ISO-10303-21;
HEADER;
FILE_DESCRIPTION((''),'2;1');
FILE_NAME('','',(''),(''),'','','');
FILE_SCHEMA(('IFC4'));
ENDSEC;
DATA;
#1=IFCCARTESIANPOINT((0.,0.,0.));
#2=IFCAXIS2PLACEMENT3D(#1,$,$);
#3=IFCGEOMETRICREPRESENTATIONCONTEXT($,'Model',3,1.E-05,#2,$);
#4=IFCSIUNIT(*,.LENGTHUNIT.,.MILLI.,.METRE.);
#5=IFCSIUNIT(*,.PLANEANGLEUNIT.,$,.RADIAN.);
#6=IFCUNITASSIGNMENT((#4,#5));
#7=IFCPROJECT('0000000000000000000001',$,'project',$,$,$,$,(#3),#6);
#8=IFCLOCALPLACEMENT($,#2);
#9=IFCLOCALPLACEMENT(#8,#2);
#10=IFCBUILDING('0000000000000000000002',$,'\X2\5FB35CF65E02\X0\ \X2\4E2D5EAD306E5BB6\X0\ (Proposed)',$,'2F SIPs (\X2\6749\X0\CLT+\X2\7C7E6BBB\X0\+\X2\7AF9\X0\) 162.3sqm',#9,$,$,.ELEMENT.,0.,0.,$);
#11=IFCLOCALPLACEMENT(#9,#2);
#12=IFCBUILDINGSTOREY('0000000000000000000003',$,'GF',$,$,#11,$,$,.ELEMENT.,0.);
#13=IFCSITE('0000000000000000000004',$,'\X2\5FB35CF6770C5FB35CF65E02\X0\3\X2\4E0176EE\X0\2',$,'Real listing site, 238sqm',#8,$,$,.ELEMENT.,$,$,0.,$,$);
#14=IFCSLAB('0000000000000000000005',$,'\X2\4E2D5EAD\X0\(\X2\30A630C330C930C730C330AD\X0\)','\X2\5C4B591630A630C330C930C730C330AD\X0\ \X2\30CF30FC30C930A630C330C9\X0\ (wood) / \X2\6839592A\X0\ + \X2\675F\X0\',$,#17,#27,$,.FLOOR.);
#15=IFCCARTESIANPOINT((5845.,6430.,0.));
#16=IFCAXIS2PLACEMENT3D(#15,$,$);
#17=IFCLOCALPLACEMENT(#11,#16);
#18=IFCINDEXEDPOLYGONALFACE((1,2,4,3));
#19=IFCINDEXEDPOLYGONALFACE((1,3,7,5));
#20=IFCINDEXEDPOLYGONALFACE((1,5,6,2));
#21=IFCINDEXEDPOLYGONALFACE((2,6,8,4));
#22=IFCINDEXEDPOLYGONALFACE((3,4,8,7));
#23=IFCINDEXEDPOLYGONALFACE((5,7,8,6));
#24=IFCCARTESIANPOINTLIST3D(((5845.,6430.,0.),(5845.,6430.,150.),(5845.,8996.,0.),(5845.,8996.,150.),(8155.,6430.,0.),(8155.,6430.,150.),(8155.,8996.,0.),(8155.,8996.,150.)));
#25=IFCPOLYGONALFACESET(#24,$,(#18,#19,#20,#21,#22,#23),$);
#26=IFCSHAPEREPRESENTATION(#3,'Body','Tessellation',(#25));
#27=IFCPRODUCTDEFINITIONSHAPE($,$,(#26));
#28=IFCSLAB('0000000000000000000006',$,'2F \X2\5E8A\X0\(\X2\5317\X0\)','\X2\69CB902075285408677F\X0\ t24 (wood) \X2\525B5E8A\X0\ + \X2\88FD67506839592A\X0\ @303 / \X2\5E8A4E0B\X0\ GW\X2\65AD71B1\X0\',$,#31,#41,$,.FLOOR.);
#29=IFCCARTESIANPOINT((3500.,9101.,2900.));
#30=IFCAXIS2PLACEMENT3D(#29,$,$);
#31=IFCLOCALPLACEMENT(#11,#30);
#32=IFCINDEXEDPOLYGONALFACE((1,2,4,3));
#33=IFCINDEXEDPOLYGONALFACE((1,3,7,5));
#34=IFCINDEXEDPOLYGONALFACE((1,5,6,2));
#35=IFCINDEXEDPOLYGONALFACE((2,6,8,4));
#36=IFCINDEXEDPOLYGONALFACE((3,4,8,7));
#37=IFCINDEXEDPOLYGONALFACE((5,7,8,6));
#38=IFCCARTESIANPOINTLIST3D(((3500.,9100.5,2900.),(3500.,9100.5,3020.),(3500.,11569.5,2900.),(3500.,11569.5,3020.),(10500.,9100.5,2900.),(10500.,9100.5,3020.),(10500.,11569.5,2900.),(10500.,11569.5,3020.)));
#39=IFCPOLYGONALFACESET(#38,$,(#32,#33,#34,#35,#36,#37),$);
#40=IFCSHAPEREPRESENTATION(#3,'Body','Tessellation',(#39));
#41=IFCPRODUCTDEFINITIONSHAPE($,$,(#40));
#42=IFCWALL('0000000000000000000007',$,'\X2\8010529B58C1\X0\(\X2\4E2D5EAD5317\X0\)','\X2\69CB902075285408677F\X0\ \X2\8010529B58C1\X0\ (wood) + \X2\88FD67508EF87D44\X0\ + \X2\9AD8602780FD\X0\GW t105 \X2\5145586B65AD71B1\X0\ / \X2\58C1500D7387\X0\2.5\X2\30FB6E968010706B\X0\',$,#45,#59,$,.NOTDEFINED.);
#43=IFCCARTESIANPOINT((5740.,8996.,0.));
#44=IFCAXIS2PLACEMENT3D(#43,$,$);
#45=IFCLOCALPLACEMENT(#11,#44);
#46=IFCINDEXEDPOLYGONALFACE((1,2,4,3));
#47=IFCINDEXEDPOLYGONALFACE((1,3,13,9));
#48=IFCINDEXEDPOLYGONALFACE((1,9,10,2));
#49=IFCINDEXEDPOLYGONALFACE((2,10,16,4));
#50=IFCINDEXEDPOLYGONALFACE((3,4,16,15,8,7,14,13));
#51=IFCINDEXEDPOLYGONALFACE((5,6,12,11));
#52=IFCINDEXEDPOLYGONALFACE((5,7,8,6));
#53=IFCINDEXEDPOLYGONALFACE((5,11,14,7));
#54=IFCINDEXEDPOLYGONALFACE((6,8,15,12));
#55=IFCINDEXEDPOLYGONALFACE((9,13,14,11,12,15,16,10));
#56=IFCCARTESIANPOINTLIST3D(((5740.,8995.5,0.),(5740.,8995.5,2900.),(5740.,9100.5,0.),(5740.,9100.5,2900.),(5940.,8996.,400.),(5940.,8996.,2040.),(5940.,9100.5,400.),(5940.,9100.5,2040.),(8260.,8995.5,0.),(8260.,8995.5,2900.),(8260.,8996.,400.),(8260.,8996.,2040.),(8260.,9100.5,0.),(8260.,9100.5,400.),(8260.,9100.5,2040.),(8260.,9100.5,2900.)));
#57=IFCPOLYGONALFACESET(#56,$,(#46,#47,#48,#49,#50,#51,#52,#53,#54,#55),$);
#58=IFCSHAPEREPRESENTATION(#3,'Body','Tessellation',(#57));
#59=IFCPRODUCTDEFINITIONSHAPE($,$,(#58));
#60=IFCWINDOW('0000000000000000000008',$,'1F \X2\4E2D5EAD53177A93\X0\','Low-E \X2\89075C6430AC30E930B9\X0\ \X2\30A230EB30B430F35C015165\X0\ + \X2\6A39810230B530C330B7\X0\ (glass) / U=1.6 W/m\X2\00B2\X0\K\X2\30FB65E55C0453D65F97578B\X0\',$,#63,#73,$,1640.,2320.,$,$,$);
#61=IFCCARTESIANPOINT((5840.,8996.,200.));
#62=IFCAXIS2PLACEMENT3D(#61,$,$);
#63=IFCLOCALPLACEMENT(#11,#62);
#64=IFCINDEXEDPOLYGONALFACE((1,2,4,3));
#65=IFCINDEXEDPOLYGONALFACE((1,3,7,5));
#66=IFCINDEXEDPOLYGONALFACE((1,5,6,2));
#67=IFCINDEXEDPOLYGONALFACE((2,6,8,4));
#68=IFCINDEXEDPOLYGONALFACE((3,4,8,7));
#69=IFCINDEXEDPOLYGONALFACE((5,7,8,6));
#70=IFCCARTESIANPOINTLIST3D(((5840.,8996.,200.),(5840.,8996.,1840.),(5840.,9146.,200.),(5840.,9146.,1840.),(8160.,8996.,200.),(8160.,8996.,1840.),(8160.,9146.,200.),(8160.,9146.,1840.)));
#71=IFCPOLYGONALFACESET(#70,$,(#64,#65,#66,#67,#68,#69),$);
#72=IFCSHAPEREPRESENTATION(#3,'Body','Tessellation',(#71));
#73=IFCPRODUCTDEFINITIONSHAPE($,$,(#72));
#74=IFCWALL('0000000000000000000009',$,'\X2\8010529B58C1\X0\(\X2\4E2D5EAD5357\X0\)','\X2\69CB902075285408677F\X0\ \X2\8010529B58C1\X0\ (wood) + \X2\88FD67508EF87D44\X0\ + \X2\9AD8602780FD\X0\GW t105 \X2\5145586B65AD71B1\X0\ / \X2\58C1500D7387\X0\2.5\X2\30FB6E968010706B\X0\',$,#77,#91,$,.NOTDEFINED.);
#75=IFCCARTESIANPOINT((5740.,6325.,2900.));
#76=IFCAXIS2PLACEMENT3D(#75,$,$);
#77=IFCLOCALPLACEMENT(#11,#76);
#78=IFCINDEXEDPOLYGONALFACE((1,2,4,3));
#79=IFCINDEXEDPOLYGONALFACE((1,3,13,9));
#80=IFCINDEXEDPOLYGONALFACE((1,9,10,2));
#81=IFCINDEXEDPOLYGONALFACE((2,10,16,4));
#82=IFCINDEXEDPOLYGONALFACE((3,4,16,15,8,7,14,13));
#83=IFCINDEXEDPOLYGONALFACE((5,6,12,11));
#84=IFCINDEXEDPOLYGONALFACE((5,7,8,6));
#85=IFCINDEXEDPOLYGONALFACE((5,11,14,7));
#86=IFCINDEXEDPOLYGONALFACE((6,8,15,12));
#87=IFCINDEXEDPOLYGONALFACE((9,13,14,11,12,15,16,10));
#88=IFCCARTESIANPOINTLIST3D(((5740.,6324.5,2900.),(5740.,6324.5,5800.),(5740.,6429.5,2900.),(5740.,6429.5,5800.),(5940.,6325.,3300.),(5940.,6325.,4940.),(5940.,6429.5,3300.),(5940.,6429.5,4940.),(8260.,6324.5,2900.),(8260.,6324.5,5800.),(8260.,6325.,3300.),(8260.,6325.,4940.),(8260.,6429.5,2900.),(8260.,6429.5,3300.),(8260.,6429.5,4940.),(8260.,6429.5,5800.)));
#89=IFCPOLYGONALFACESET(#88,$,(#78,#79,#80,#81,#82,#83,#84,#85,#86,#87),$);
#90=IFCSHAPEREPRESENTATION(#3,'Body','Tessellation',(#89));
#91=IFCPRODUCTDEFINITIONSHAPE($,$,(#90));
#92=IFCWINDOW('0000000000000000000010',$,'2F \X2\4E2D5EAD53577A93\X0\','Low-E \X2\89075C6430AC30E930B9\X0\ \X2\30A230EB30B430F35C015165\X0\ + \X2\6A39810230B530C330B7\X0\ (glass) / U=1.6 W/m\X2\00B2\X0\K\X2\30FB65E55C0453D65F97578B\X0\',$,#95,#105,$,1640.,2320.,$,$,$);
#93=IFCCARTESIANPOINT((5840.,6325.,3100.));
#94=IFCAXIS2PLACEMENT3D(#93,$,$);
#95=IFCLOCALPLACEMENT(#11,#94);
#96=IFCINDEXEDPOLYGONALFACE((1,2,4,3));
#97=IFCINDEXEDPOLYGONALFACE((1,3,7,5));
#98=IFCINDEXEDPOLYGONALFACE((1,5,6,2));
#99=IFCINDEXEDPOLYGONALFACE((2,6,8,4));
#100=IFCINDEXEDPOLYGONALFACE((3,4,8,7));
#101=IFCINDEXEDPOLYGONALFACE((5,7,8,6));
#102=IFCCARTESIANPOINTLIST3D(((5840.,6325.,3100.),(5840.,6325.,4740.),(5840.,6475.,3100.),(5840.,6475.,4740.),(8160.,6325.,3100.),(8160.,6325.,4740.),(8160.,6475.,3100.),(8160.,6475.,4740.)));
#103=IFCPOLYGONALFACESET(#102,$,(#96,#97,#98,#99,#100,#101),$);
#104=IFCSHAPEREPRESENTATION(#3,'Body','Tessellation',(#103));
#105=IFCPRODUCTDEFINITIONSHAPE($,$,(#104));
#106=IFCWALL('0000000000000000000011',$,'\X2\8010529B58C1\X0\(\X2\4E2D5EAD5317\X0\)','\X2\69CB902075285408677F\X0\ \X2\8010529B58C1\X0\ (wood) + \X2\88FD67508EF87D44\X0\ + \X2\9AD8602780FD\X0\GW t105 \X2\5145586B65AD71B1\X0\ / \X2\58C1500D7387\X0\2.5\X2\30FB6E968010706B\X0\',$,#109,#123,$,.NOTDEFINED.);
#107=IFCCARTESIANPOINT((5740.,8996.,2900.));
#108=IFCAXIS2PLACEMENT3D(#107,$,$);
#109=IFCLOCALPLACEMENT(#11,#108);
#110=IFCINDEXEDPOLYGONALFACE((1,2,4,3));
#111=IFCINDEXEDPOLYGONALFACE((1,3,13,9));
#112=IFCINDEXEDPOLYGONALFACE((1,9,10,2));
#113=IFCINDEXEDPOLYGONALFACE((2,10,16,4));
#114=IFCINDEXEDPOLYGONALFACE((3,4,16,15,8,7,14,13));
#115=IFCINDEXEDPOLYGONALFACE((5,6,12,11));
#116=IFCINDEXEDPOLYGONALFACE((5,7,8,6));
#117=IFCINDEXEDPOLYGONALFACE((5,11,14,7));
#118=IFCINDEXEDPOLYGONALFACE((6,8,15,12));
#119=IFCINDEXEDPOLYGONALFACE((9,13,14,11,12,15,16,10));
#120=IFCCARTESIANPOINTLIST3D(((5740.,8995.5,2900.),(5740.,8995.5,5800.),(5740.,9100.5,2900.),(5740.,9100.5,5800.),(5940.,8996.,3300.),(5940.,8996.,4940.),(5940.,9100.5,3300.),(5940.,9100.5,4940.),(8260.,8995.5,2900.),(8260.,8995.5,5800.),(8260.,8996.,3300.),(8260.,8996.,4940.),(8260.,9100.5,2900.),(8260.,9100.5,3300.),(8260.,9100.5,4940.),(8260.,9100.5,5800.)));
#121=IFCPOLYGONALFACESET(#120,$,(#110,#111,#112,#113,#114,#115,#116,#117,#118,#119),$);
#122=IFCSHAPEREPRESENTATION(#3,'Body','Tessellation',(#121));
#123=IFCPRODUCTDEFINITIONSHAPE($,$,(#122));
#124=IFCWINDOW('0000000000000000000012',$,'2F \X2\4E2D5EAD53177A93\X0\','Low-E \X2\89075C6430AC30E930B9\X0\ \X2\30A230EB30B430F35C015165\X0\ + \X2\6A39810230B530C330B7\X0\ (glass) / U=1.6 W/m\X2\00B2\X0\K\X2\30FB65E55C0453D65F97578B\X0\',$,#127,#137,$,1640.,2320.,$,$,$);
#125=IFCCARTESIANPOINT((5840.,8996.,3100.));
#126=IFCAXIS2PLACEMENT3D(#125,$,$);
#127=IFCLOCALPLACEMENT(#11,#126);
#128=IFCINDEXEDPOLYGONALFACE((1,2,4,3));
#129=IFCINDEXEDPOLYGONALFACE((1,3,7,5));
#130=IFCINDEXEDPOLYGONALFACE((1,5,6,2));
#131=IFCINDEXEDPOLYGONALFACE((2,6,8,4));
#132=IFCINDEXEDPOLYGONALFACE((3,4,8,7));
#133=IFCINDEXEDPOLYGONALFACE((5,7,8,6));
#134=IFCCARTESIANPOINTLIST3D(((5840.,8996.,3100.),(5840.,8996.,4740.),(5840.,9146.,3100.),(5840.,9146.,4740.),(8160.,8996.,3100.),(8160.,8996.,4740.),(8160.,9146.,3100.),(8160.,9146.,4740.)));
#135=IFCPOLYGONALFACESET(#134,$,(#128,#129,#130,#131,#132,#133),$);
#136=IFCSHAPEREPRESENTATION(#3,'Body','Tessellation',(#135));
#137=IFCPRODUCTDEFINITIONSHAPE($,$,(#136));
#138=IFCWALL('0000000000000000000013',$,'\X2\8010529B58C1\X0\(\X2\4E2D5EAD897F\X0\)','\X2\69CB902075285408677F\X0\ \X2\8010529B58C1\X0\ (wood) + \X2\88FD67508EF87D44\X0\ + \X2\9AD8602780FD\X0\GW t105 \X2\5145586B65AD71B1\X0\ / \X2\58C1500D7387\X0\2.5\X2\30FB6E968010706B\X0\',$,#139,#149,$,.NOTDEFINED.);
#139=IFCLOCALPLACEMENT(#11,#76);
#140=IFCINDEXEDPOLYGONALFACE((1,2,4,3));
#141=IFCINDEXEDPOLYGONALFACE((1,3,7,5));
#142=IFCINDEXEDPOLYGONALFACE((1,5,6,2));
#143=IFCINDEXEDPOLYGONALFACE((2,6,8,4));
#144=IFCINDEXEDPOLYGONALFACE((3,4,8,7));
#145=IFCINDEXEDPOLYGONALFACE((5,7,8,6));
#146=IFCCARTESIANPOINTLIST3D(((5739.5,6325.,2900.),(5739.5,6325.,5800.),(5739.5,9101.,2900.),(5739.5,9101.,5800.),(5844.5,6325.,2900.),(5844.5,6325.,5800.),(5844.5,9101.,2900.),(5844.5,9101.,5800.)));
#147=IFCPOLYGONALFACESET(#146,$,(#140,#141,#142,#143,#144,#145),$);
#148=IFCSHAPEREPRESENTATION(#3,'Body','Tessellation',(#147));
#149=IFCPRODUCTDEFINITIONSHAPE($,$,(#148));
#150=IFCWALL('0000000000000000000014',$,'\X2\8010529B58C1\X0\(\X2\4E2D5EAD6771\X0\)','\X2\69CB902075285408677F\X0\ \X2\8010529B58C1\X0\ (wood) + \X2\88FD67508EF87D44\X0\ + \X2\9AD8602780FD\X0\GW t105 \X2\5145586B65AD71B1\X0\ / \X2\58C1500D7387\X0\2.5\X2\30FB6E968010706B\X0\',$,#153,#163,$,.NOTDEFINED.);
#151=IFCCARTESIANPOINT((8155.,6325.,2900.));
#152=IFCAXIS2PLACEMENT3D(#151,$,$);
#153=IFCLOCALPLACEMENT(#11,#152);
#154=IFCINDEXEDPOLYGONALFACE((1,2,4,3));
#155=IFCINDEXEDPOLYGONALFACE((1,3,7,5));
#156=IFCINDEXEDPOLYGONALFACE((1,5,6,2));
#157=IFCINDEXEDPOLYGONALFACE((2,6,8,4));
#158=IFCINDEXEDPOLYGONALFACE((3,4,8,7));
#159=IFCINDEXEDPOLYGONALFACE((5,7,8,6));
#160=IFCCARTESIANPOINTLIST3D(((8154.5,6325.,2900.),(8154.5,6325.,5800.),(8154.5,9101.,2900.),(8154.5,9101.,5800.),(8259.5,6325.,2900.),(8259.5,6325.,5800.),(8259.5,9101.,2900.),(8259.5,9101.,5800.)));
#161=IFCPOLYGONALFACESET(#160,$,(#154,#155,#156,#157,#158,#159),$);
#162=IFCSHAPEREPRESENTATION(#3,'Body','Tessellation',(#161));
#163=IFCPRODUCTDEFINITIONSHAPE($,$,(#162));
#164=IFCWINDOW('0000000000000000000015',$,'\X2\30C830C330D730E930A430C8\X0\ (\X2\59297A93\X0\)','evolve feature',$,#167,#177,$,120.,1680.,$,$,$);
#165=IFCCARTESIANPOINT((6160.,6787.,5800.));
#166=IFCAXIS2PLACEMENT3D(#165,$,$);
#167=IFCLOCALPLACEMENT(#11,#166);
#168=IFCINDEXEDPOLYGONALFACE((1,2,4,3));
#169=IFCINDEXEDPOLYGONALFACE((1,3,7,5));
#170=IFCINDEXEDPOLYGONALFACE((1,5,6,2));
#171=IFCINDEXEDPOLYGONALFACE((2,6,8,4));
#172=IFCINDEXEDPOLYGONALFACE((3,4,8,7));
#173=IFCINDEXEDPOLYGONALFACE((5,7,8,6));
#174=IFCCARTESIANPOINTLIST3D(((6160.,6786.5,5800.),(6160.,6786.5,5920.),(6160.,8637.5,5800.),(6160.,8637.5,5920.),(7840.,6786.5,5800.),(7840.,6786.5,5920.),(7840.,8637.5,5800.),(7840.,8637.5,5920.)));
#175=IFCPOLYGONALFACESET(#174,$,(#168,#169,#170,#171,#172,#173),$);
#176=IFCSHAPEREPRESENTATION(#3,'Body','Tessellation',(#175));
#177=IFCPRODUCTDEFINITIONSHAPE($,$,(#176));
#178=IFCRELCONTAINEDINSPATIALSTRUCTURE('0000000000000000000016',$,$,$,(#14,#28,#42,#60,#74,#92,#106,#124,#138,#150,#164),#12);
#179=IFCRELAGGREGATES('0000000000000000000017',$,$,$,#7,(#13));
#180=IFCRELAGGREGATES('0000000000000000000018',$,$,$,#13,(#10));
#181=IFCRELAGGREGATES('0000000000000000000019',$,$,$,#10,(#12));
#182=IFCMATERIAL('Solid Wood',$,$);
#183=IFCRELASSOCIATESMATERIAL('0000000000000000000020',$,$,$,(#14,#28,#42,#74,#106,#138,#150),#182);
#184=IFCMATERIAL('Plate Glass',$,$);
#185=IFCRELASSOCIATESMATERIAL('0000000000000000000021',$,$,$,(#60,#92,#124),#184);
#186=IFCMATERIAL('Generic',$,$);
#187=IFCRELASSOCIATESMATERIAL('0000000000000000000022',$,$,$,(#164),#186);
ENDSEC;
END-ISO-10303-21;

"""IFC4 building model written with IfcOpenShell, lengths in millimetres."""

from ifc_helpers import new_model, si_unit, frame, frame_2d, origin, place, context, project, spatial, rectangle, extrude, material, element, fill, save


model = new_model("IFC4")

# Units and contexts
model_context = context("Model", 3, precision=1e-05, world=origin())
ifc_project = project(units=[si_unit("LENGTHUNIT", "METRE", prefix="MILLI"), si_unit("PLANEANGLEUNIT", "RADIAN")], contexts=[model_context])

# Site, building, storey
site_placement = place(None, origin())
site = spatial("IfcSite", under=ifc_project, at=site_placement, Name="徳島県徳島市3丁目2", ObjectType="Real listing site, 238sqm", CompositionType="ELEMENT", RefElevation=0.0)
building_placement = place(site_placement, origin())
building = spatial("IfcBuilding", under=site, at=building_placement, Name="徳島市 中庭の家 (Proposed)", ObjectType="2F SIPs (杉CLT+籾殻+竹) 162.3sqm", CompositionType="ELEMENT", ElevationOfRefHeight=0.0, ElevationOfTerrain=0.0)
storey_placement = place(building_placement, origin())
storey = spatial("IfcBuildingStorey", under=building, at=storey_placement, Name="GF", CompositionType="ELEMENT", Elevation=0.0)

# Slabs
ifc_material_1 = material(Name="Solid Wood")
slab_1_placement = place(storey_placement, frame((5845.0, 6430.0, 0.0)))
element("IfcSlab", 1, at=slab_1_placement, inside=storey, material=ifc_material_1, Name="中庭(ウッドデッキ)", Description="屋外ウッドデッキ ハードウッド (wood) / 根太 + 束", PredefinedType="FLOOR", context=model_context, shape_type="SweptSolid", body=[
    extrude(rectangle(XDim=2310.0, YDim=2566.0, at=frame_2d((1155.0, 1283.0))), frame((5845.0, 6430.0, 0.0)), (0.0, 0.0, 1.0), 150.0),
])
slab_2_placement = place(storey_placement, frame((3500.0, 9101.0, 2900.0)))
element("IfcSlab", 2, at=slab_2_placement, inside=storey, material=ifc_material_1, Name="2F 床(北)", Description="構造用合板 t24 (wood) 剛床 + 製材根太 @303 / 床下 GW断熱", PredefinedType="FLOOR", context=model_context, shape_type="SweptSolid", body=[
    extrude(rectangle(XDim=7000.0, YDim=2469.0, at=frame_2d((3500.0, 1234.0))), frame((3500.0, 9101.0, 2900.0)), (0.0, 0.0, 1.0), 120.0),
])
ifc_material_2 = material(Name="Generic")

# Wall, opening, window
wall_1_placement = place(storey_placement, frame((5740.0, 8996.0, 0.0)))
wall_1 = element("IfcWall", 3, at=wall_1_placement, inside=storey, material=ifc_material_1, Name="耐力壁(中庭北)", Description="構造用合板 耐力壁 (wood) + 製材軸組 + 高性能GW t105 充填断熱 / 壁倍率2.5・準耐火", PredefinedType="NOTDEFINED", context=model_context, shape_type="SweptSolid", body=[
    extrude(rectangle(XDim=2520.0, YDim=105.0, at=frame_2d((1260.0, 52.0))), frame((5740.0, 8996.0, 0.0)), (0.0, 0.0, 1.0), 2900.0),
])
opening_1_placement = place(storey_placement, frame((5840.0, 8996.0, 200.0)))
opening_1 = element("IfcOpeningElement", 4, at=opening_1_placement, cuts=wall_1, PredefinedType="NOTDEFINED", context=model_context, shape_type="SweptSolid", body=[
    extrude(rectangle(XDim=2320.0, YDim=150.0, at=frame_2d((1160.0, 75.0))), frame((5840.0, 8996.0, 200.0)), (0.0, 0.0, 1.0), 1640.0),
])
ifc_material_3 = material(Name="Plate Glass")
window_1_placement = place(storey_placement, frame((5840.0, 8996.0, 200.0)))
window_1 = element("IfcWindow", 5, at=window_1_placement, inside=storey, material=ifc_material_3, Name="1F 中庭北窓", Description="Low-E 複層ガラス アルゴン封入 + 樹脂サッシ (glass) / U=1.6 W/m²K・日射取得型", OverallHeight=1640.0, OverallWidth=2320.0, context=model_context, shape_type="SweptSolid", body=[
    extrude(rectangle(XDim=2320.0, YDim=150.0, at=frame_2d((1160.0, 75.0))), frame((5840.0, 8996.0, 200.0)), (0.0, 0.0, 1.0), 1640.0),
])
fill(opening_1, window_1)

# Walls, openings, windows
wall_2_placement = place(storey_placement, frame((5740.0, 6325.0, 2900.0)))
wall_2 = element("IfcWall", 6, at=wall_2_placement, inside=storey, material=ifc_material_1, Name="耐力壁(中庭南)", Description="構造用合板 耐力壁 (wood) + 製材軸組 + 高性能GW t105 充填断熱 / 壁倍率2.5・準耐火", PredefinedType="NOTDEFINED", context=model_context, shape_type="SweptSolid", body=[
    extrude(rectangle(XDim=2520.0, YDim=105.0, at=frame_2d((1260.0, 52.0))), frame((5740.0, 6325.0, 2900.0)), (0.0, 0.0, 1.0), 2900.0),
])
opening_2_placement = place(storey_placement, frame((5840.0, 6325.0, 3100.0)))
opening_2 = element("IfcOpeningElement", 7, at=opening_2_placement, cuts=wall_2, PredefinedType="NOTDEFINED", context=model_context, shape_type="SweptSolid", body=[
    extrude(rectangle(XDim=2320.0, YDim=150.0, at=frame_2d((1160.0, 75.0))), frame((5840.0, 6325.0, 3100.0)), (0.0, 0.0, 1.0), 1640.0),
])
window_2_placement = place(storey_placement, frame((5840.0, 6325.0, 3100.0)))
window_2 = element("IfcWindow", 8, at=window_2_placement, inside=storey, material=ifc_material_3, Name="2F 中庭南窓", Description="Low-E 複層ガラス アルゴン封入 + 樹脂サッシ (glass) / U=1.6 W/m²K・日射取得型", OverallHeight=1640.0, OverallWidth=2320.0, context=model_context, shape_type="SweptSolid", body=[
    extrude(rectangle(XDim=2320.0, YDim=150.0, at=frame_2d((1160.0, 75.0))), frame((5840.0, 6325.0, 3100.0)), (0.0, 0.0, 1.0), 1640.0),
])
fill(opening_2, window_2)
wall_3_placement = place(storey_placement, frame((5740.0, 8996.0, 2900.0)))
wall_3 = element("IfcWall", 9, at=wall_3_placement, inside=storey, material=ifc_material_1, Name="耐力壁(中庭北)", Description="構造用合板 耐力壁 (wood) + 製材軸組 + 高性能GW t105 充填断熱 / 壁倍率2.5・準耐火", PredefinedType="NOTDEFINED", context=model_context, shape_type="SweptSolid", body=[
    extrude(rectangle(XDim=2520.0, YDim=105.0, at=frame_2d((1260.0, 52.0))), frame((5740.0, 8996.0, 2900.0)), (0.0, 0.0, 1.0), 2900.0),
])
opening_3_placement = place(storey_placement, frame((5840.0, 8996.0, 3100.0)))
opening_3 = element("IfcOpeningElement", 10, at=opening_3_placement, cuts=wall_3, PredefinedType="NOTDEFINED", context=model_context, shape_type="SweptSolid", body=[
    extrude(rectangle(XDim=2320.0, YDim=150.0, at=frame_2d((1160.0, 75.0))), frame((5840.0, 8996.0, 3100.0)), (0.0, 0.0, 1.0), 1640.0),
])
window_3_placement = place(storey_placement, frame((5840.0, 8996.0, 3100.0)))
window_3 = element("IfcWindow", 11, at=window_3_placement, inside=storey, material=ifc_material_3, Name="2F 中庭北窓", Description="Low-E 複層ガラス アルゴン封入 + 樹脂サッシ (glass) / U=1.6 W/m²K・日射取得型", OverallHeight=1640.0, OverallWidth=2320.0, context=model_context, shape_type="SweptSolid", body=[
    extrude(rectangle(XDim=2320.0, YDim=150.0, at=frame_2d((1160.0, 75.0))), frame((5840.0, 8996.0, 3100.0)), (0.0, 0.0, 1.0), 1640.0),
])
fill(opening_3, window_3)

# Walls
wall_4_placement = place(storey_placement, frame((5740.0, 6325.0, 2900.0)))
element("IfcWall", 12, at=wall_4_placement, inside=storey, material=ifc_material_1, Name="耐力壁(中庭西)", Description="構造用合板 耐力壁 (wood) + 製材軸組 + 高性能GW t105 充填断熱 / 壁倍率2.5・準耐火", PredefinedType="NOTDEFINED", context=model_context, shape_type="SweptSolid", body=[
    extrude(rectangle(XDim=105.0, YDim=2776.0, at=frame_2d((52.0, 1388.0))), frame((5740.0, 6325.0, 2900.0)), (0.0, 0.0, 1.0), 2900.0),
])
wall_5_placement = place(storey_placement, frame((8155.0, 6325.0, 2900.0)))
element("IfcWall", 13, at=wall_5_placement, inside=storey, material=ifc_material_1, Name="耐力壁(中庭東)", Description="構造用合板 耐力壁 (wood) + 製材軸組 + 高性能GW t105 充填断熱 / 壁倍率2.5・準耐火", PredefinedType="NOTDEFINED", context=model_context, shape_type="SweptSolid", body=[
    extrude(rectangle(XDim=105.0, YDim=2776.0, at=frame_2d((52.0, 1388.0))), frame((8155.0, 6325.0, 2900.0)), (0.0, 0.0, 1.0), 2900.0),
])

# Window
window_4_placement = place(storey_placement, frame((6160.0, 6787.0, 5800.0)))
element("IfcWindow", 14, at=window_4_placement, inside=storey, material=ifc_material_2, Name="トップライト (天窓)", Description="evolve feature", OverallHeight=120.0, OverallWidth=1680.0, context=model_context, shape_type="SweptSolid", body=[
    extrude(rectangle(XDim=1680.0, YDim=1851.0, at=frame_2d((840.0, 925.0))), frame((6160.0, 6787.0, 5800.0)), (0.0, 0.0, 1.0), 120.0),
])

save(model, "model.ifc")
